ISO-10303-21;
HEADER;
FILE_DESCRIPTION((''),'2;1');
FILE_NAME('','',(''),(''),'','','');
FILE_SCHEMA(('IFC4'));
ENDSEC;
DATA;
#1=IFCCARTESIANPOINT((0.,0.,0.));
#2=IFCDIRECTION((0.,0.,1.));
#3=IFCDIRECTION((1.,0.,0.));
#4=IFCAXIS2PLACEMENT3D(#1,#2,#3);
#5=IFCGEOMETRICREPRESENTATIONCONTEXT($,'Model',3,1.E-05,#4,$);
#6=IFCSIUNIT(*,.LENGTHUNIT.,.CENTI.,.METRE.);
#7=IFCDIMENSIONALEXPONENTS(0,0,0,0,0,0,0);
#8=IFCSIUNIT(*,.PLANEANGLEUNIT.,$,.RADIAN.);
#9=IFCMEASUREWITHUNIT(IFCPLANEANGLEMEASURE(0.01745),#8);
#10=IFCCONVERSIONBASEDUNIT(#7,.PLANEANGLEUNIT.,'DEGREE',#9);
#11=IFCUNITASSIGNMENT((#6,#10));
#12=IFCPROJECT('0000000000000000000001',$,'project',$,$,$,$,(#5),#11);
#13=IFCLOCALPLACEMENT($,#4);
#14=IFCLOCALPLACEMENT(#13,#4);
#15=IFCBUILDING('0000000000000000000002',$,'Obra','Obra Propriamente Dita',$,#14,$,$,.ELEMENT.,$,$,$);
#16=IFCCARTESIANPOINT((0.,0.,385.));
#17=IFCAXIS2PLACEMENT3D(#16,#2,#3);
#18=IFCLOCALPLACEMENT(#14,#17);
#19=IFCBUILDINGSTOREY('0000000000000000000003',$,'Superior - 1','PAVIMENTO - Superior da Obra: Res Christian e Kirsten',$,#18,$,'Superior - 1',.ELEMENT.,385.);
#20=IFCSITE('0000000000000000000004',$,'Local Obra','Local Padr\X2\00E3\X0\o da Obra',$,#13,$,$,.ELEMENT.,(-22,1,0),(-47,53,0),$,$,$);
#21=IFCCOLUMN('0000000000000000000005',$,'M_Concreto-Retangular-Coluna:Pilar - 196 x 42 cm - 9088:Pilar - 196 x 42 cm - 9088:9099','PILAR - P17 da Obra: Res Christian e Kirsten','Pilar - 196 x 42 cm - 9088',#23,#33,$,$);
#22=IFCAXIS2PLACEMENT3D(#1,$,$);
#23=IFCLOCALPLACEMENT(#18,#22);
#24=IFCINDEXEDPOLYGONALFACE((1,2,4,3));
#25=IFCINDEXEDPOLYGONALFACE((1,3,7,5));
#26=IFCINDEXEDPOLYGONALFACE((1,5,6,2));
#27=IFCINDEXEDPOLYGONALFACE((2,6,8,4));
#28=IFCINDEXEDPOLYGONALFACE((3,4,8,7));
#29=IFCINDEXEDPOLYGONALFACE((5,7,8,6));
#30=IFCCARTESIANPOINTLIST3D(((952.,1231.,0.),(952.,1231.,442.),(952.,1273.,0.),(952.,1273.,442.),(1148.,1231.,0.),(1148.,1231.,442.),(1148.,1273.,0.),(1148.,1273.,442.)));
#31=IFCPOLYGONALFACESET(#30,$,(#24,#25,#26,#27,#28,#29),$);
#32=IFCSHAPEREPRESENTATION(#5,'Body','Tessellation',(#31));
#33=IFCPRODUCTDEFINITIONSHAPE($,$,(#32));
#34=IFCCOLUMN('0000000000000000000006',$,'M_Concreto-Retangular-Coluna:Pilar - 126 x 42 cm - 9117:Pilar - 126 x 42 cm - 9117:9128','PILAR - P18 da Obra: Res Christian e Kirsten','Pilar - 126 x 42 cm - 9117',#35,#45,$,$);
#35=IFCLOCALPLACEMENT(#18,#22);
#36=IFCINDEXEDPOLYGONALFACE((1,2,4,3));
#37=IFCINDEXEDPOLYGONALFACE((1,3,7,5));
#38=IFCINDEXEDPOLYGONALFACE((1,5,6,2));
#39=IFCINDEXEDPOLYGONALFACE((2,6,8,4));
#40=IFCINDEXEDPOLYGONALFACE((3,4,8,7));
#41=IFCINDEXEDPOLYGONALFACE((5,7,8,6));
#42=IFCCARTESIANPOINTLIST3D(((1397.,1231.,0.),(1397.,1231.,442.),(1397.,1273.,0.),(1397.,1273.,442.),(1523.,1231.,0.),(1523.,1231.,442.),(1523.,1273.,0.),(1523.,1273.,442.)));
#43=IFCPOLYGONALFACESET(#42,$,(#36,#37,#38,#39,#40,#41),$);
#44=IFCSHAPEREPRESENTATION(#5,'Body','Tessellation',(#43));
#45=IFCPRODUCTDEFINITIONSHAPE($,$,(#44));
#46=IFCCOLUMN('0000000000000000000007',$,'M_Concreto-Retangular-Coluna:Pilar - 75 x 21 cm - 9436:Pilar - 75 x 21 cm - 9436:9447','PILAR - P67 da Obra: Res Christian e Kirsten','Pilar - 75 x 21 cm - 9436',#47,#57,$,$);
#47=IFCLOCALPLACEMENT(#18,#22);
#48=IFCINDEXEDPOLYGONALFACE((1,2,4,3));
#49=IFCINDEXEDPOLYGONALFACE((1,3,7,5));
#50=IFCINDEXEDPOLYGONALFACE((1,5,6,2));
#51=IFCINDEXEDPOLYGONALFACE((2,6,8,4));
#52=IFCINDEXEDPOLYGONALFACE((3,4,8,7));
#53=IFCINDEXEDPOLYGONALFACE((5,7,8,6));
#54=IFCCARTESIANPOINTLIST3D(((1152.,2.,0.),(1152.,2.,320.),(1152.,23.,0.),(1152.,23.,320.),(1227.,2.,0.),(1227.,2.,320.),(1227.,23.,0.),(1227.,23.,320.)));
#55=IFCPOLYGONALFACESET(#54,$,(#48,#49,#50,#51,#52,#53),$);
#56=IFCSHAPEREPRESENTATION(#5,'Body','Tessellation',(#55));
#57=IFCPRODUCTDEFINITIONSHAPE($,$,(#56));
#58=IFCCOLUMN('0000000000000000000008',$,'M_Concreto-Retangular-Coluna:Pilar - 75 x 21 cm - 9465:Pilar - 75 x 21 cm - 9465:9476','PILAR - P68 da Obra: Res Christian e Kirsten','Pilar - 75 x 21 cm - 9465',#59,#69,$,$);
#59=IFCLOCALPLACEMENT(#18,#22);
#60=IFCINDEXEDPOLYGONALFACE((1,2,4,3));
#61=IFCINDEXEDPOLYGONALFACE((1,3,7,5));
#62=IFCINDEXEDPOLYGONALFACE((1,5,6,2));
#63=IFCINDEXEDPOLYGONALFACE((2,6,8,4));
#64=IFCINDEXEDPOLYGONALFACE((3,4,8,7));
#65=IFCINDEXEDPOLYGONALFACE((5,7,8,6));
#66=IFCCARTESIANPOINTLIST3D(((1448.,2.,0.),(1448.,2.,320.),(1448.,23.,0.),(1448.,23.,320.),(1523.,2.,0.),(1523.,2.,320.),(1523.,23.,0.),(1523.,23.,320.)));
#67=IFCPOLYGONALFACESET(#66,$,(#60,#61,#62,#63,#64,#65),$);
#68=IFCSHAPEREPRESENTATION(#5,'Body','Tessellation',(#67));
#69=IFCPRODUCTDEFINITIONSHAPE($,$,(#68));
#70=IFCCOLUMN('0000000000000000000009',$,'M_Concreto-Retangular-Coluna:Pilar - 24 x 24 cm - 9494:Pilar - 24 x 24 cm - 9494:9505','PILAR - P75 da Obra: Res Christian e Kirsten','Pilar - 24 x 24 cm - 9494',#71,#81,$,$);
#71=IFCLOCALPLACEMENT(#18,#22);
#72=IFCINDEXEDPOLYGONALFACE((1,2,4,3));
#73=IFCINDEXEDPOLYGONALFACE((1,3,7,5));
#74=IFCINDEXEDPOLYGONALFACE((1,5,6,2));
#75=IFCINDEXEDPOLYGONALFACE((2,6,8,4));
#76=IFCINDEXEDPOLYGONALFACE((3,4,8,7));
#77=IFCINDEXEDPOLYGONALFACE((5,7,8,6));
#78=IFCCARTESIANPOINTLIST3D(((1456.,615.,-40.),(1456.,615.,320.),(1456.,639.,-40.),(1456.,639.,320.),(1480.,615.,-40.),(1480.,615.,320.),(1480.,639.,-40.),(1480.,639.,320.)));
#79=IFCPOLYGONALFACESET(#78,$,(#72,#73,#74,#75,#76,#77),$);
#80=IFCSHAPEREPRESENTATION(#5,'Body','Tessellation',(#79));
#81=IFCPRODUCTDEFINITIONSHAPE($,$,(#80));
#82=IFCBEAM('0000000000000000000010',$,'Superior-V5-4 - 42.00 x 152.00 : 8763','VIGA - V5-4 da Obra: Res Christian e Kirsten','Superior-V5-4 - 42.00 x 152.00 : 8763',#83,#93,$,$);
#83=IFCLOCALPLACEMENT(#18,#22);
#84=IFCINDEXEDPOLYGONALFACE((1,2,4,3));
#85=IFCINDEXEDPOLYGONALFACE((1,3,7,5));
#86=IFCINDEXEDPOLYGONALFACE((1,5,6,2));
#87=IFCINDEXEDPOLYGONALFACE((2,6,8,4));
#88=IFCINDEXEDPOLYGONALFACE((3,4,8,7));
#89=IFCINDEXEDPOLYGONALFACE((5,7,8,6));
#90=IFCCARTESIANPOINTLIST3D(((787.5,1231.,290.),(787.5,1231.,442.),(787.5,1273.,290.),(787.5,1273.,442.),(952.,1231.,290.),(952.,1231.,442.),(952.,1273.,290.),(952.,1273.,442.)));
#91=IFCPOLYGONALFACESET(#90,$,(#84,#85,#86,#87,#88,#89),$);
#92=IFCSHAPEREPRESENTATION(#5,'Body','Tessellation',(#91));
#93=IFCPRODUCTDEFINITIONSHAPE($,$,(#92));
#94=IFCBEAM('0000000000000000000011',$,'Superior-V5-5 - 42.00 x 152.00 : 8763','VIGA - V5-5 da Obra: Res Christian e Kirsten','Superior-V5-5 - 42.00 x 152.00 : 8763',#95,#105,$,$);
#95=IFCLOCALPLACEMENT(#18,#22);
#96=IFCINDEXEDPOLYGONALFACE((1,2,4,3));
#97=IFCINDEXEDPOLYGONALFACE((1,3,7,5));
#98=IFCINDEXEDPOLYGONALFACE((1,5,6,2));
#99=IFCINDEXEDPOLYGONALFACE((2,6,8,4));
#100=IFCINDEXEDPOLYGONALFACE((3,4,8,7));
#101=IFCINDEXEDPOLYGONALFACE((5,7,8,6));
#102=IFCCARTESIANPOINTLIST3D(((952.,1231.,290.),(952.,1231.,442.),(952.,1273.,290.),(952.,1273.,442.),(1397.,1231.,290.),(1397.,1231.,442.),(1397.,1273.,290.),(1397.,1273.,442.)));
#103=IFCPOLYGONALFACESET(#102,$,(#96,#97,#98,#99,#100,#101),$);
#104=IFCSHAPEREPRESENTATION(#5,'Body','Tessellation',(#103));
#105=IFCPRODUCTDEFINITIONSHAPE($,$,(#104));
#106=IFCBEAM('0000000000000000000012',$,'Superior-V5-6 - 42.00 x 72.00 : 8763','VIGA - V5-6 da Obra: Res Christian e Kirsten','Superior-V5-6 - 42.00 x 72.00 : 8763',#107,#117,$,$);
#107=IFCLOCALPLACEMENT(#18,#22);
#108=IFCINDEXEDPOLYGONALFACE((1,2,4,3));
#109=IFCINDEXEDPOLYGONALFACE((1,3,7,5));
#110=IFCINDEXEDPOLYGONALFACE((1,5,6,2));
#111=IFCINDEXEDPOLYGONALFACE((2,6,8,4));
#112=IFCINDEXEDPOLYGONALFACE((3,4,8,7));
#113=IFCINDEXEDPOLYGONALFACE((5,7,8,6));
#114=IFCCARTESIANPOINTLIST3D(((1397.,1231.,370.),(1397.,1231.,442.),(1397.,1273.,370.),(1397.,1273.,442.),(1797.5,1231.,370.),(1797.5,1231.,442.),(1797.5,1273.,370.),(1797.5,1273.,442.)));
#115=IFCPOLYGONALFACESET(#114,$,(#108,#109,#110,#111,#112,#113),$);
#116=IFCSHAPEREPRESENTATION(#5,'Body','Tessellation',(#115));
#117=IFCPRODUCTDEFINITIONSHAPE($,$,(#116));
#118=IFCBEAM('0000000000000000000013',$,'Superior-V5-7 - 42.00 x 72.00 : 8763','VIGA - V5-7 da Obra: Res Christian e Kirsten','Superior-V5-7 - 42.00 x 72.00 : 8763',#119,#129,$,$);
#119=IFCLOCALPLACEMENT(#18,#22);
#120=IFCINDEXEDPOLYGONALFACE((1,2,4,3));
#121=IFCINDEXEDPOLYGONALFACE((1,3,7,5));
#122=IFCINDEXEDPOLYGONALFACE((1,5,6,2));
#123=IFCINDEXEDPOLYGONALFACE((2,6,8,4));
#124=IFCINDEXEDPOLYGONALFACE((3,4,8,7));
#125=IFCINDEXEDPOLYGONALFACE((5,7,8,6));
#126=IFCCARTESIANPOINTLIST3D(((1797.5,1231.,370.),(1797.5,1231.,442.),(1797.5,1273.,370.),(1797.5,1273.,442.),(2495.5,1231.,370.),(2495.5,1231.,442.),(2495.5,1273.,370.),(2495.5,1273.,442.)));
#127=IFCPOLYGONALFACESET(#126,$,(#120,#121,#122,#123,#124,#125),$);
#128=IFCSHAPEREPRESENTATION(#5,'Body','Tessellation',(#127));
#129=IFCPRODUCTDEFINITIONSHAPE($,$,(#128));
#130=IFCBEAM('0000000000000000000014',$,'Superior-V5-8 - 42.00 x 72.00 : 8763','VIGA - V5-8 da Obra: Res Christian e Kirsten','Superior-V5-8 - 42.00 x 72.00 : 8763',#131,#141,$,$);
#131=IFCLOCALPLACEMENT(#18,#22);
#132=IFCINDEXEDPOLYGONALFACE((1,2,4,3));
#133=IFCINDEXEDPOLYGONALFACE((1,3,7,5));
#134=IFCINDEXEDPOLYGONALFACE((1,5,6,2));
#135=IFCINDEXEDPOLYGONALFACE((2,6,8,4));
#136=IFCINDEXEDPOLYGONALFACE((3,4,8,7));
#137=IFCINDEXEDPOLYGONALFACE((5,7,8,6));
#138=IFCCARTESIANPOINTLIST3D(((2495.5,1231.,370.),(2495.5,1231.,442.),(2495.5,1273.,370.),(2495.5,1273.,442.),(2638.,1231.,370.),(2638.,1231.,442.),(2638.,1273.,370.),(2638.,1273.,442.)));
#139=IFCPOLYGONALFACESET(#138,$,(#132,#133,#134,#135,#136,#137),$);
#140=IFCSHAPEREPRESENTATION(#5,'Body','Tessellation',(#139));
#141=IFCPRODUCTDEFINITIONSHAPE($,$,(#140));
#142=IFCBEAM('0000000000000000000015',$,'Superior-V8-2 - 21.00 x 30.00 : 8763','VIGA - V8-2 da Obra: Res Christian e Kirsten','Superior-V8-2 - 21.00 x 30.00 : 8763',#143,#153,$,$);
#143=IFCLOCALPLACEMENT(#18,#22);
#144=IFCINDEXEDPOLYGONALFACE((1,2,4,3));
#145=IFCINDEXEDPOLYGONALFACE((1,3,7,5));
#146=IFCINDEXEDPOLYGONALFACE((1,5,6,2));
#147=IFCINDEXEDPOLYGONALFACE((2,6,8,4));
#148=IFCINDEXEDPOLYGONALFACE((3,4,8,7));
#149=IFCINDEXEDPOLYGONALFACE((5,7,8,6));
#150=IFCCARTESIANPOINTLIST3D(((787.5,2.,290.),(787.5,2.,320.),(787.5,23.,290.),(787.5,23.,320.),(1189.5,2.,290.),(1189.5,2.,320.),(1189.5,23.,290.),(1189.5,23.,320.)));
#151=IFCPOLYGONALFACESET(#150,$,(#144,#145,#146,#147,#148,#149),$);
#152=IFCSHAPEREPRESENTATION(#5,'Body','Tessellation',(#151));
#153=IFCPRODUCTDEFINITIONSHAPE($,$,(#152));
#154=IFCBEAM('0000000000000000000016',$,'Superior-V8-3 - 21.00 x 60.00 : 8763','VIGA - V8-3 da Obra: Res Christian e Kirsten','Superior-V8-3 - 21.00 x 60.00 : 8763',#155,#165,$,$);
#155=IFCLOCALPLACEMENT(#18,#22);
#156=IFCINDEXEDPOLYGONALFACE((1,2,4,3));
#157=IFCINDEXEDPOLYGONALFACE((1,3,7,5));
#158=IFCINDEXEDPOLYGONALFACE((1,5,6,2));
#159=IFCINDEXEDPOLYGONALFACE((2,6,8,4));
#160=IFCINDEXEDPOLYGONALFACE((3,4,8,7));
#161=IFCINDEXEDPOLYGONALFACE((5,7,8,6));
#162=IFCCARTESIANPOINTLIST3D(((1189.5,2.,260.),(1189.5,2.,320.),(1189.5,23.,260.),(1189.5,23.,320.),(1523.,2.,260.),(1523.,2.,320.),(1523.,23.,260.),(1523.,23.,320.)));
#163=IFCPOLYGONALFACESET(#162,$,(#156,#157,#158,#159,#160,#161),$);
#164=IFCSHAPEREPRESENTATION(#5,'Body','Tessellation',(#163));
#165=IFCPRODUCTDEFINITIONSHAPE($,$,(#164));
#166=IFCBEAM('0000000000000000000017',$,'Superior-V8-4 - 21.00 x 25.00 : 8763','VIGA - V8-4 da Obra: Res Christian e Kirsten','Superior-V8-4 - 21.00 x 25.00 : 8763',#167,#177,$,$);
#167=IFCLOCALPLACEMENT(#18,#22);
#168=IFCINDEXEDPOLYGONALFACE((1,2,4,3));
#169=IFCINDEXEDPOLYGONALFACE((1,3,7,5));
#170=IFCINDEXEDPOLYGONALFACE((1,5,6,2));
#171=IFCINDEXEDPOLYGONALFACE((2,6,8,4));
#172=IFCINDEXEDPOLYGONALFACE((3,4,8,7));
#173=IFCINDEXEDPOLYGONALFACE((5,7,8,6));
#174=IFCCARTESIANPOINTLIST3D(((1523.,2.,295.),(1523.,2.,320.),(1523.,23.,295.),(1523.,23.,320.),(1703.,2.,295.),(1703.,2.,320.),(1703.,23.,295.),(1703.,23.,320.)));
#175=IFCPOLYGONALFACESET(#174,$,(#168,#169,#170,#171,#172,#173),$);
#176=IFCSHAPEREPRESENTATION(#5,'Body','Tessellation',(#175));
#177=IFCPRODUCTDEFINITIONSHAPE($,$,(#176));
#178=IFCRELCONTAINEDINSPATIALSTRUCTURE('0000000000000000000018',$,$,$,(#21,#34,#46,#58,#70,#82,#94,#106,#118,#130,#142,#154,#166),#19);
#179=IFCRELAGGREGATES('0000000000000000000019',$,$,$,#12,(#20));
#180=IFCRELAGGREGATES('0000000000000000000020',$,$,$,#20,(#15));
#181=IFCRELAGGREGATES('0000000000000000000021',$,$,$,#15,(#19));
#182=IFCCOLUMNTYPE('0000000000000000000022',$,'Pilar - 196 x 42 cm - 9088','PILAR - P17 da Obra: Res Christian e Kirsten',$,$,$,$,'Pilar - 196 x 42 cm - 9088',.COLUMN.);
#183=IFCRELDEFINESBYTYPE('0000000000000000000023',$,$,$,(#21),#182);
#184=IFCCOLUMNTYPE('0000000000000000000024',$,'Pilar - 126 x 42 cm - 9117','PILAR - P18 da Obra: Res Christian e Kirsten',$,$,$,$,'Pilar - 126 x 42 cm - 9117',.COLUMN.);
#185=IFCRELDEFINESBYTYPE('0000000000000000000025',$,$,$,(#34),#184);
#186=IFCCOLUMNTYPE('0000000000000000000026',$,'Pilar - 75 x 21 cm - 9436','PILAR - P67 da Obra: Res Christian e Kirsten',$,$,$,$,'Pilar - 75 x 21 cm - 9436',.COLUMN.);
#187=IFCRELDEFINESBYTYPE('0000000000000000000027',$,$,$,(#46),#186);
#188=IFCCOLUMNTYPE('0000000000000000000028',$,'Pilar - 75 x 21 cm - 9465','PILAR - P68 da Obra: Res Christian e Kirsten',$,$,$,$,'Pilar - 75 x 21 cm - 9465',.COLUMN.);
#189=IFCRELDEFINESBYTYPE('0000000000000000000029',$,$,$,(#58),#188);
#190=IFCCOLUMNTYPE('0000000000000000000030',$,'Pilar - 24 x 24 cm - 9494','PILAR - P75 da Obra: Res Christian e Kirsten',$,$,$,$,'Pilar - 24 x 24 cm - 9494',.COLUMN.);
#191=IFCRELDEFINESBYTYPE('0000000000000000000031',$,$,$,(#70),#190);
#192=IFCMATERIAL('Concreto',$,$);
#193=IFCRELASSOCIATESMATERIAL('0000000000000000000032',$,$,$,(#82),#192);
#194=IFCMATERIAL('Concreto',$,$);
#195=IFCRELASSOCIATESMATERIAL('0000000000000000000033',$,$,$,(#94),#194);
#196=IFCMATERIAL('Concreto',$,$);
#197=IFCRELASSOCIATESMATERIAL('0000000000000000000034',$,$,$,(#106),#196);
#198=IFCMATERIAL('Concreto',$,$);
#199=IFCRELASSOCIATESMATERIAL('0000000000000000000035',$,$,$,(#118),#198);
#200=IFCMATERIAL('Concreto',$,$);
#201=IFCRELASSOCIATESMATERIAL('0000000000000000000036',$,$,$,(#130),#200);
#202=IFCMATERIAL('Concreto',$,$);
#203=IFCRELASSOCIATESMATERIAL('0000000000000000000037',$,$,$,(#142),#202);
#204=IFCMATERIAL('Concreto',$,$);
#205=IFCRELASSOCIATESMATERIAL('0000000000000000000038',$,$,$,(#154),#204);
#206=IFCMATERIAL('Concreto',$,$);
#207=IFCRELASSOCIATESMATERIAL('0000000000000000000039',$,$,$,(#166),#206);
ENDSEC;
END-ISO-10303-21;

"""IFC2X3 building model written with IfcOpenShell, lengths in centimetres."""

from ifc_helpers import new_model, entity, si_unit, converted_unit, frame, origin, origin_with_axes, origin_2d_with_axis, place, context, project, spatial, polyline, rectangle, outline, extrude, source, transform, mapped, material, type_object, type_shapes, element, save


model = new_model("IFC2X3")

# Units and contexts
model_context = context("Model", 3, precision=1e-05, world=origin_with_axes())
ifc_project = project(units=[si_unit("LENGTHUNIT", "METRE", prefix="CENTI"), converted_unit("PLANEANGLEUNIT", "DEGREE", entity("IfcPlaneAngleMeasure", 0.01745), si_unit("PLANEANGLEUNIT", "RADIAN"), dimensions=[0, 0, 0, 0, 0, 0, 0])], contexts=[model_context])

# Site, building, storey
site_placement = place(None, origin_with_axes())
site = spatial("IfcSite", under=ifc_project, at=site_placement, Name="Local Obra", Description="Local Padrão da Obra", CompositionType="ELEMENT", RefLatitude=(-22, 1, 0), RefLongitude=(-47, 53, 0))
building_placement = place(site_placement, origin_with_axes())
building = spatial("IfcBuilding", under=site, at=building_placement, Name="Obra", Description="Obra Propriamente Dita", CompositionType="ELEMENT")
storey_placement = place(building_placement, frame((0.0, 0.0, 385.0), z_axis=(0.0, 0.0, 1.0), x_axis=(1.0, 0.0, 0.0)))
storey = spatial("IfcBuildingStorey", under=building, at=storey_placement, Name="Superior - 1", Description="PAVIMENTO - Superior da Obra: Res Christian e Kirsten", LongName="Superior - 1", CompositionType="ELEMENT", Elevation=385.0)

# Columns
column_type_1 = type_object("IfcColumnType", Name="Pilar - 196 x 42 cm - 9088", Description="PILAR - P17 da Obra: Res Christian e Kirsten", ElementType="Pilar - 196 x 42 cm - 9088", PredefinedType="COLUMN")
shared_shape_1 = source(origin(), model_context, "Body", "SweptSolid", [
    extrude(rectangle(XDim=196.0, YDim=42.0, at=origin_2d_with_axis()), origin(), (0.0, 0.0, 1.0), 442.0),
])
type_shapes(column_type_1, [shared_shape_1])
column_1_placement = place(storey_placement, frame((1050.0, 1252.0, 0.0), z_axis=(0.0, 0.0, 1.0), x_axis=(1.0, 0.0, 0.0)))
element("IfcColumn", 1, at=column_1_placement, inside=storey, type_object=column_type_1, Name="M_Concreto-Retangular-Coluna:Pilar - 196 x 42 cm - 9088:Pilar - 196 x 42 cm - 9088:9099", Description="PILAR - P17 da Obra: Res Christian e Kirsten", ObjectType="Pilar - 196 x 42 cm - 9088", context=model_context, shape_type="MappedRepresentation", body=[
    mapped(shared_shape_1, transform((0.0, 0.0, 0.0), scale=1.0)),
])
column_type_2 = type_object("IfcColumnType", Name="Pilar - 126 x 42 cm - 9117", Description="PILAR - P18 da Obra: Res Christian e Kirsten", ElementType="Pilar - 126 x 42 cm - 9117", PredefinedType="COLUMN")
shared_shape_2 = source(origin(), model_context, "Body", "SweptSolid", [
    extrude(rectangle(XDim=126.0, YDim=42.0, at=origin_2d_with_axis()), origin(), (0.0, 0.0, 1.0), 442.0),
])
type_shapes(column_type_2, [shared_shape_2])
column_2_placement = place(storey_placement, frame((1460.0, 1252.0, 0.0), z_axis=(0.0, 0.0, 1.0), x_axis=(1.0, 0.0, 0.0)))
element("IfcColumn", 2, at=column_2_placement, inside=storey, type_object=column_type_2, Name="M_Concreto-Retangular-Coluna:Pilar - 126 x 42 cm - 9117:Pilar - 126 x 42 cm - 9117:9128", Description="PILAR - P18 da Obra: Res Christian e Kirsten", ObjectType="Pilar - 126 x 42 cm - 9117", context=model_context, shape_type="MappedRepresentation", body=[
    mapped(shared_shape_2, transform((0.0, 0.0, 0.0), scale=1.0)),
])
column_type_3 = type_object("IfcColumnType", Name="Pilar - 75 x 21 cm - 9436", Description="PILAR - P67 da Obra: Res Christian e Kirsten", ElementType="Pilar - 75 x 21 cm - 9436", PredefinedType="COLUMN")
shared_shape_3 = source(origin(), model_context, "Body", "SweptSolid", [
    extrude(rectangle(XDim=75.0, YDim=21.0, at=origin_2d_with_axis()), origin(), (0.0, 0.0, 1.0), 320.0),
])
type_shapes(column_type_3, [shared_shape_3])
column_3_placement = place(storey_placement, frame((1189.5, 12.5, 0.0), z_axis=(0.0, 0.0, 1.0), x_axis=(1.0, 0.0, 0.0)))
element("IfcColumn", 3, at=column_3_placement, inside=storey, type_object=column_type_3, Name="M_Concreto-Retangular-Coluna:Pilar - 75 x 21 cm - 9436:Pilar - 75 x 21 cm - 9436:9447", Description="PILAR - P67 da Obra: Res Christian e Kirsten", ObjectType="Pilar - 75 x 21 cm - 9436", context=model_context, shape_type="MappedRepresentation", body=[
    mapped(shared_shape_3, transform((0.0, 0.0, 0.0), scale=1.0)),
])
column_type_4 = type_object("IfcColumnType", Name="Pilar - 75 x 21 cm - 9465", Description="PILAR - P68 da Obra: Res Christian e Kirsten", ElementType="Pilar - 75 x 21 cm - 9465", PredefinedType="COLUMN")
shared_shape_4 = source(origin(), model_context, "Body", "SweptSolid", [
    extrude(rectangle(XDim=75.0, YDim=21.0, at=origin_2d_with_axis()), origin(), (0.0, 0.0, 1.0), 320.0),
])
type_shapes(column_type_4, [shared_shape_4])
column_4_placement = place(storey_placement, frame((1485.5, 12.5, 0.0), z_axis=(0.0, 0.0, 1.0), x_axis=(1.0, 0.0, 0.0)))
element("IfcColumn", 4, at=column_4_placement, inside=storey, type_object=column_type_4, Name="M_Concreto-Retangular-Coluna:Pilar - 75 x 21 cm - 9465:Pilar - 75 x 21 cm - 9465:9476", Description="PILAR - P68 da Obra: Res Christian e Kirsten", ObjectType="Pilar - 75 x 21 cm - 9465", context=model_context, shape_type="MappedRepresentation", body=[
    mapped(shared_shape_4, transform((0.0, 0.0, 0.0), scale=1.0)),
])
column_type_5 = type_object("IfcColumnType", Name="Pilar - 24 x 24 cm - 9494", Description="PILAR - P75 da Obra: Res Christian e Kirsten", ElementType="Pilar - 24 x 24 cm - 9494", PredefinedType="COLUMN")
shared_shape_5 = source(origin(), model_context, "Body", "SweptSolid", [
    extrude(rectangle(XDim=24.0, YDim=24.0, at=origin_2d_with_axis()), origin(), (0.0, 0.0, 1.0), 360.0),
])
type_shapes(column_type_5, [shared_shape_5])
column_5_placement = place(storey_placement, frame((1468.0, 627.0, -40.0), z_axis=(0.0, 0.0, 1.0), x_axis=(1.0, 0.0, 0.0)))
element("IfcColumn", 5, at=column_5_placement, inside=storey, type_object=column_type_5, Name="M_Concreto-Retangular-Coluna:Pilar - 24 x 24 cm - 9494:Pilar - 24 x 24 cm - 9494:9505", Description="PILAR - P75 da Obra: Res Christian e Kirsten", ObjectType="Pilar - 24 x 24 cm - 9494", context=model_context, shape_type="MappedRepresentation", body=[
    mapped(shared_shape_5, transform((0.0, 0.0, 0.0), scale=1.0)),
])

# Beams
ifc_material_1 = material(Name="Concreto")
beam_1_placement = place(storey_placement, frame((787.5, 1252.0, 442.0), z_axis=(1.0, 0.0, 0.0), x_axis=(0.0, -1.0, 0.0)))
element("IfcBeam", 6, at=beam_1_placement, inside=storey, material=ifc_material_1, Name="Superior-V5-4 - 42.00 x 152.00 : 8763", Description="VIGA - V5-4 da Obra: Res Christian e Kirsten", ObjectType="Superior-V5-4 - 42.00 x 152.00 : 8763", context=model_context, shape_type="SweptSolid", body=[
    extrude(outline(polyline([(-21.0, 0.0), (21.0, 0.0), (21.0, 152.0), (-21.0, 152.0), (-21.0, 0.0)])), origin_with_axes(), (0.0, 0.0, 1.0), 164.5),
])
ifc_material_2 = material(Name="Concreto")
beam_2_placement = place(storey_placement, frame((952.0, 1252.0, 442.0), z_axis=(1.0, 0.0, 0.0), x_axis=(0.0, -1.0, 0.0)))
element("IfcBeam", 7, at=beam_2_placement, inside=storey, material=ifc_material_2, Name="Superior-V5-5 - 42.00 x 152.00 : 8763", Description="VIGA - V5-5 da Obra: Res Christian e Kirsten", ObjectType="Superior-V5-5 - 42.00 x 152.00 : 8763", context=model_context, shape_type="SweptSolid", body=[
    extrude(outline(polyline([(-21.0, 0.0), (21.0, 0.0), (21.0, 152.0), (-21.0, 152.0), (-21.0, 0.0)])), origin_with_axes(), (0.0, 0.0, 1.0), 445.0),
])
ifc_material_3 = material(Name="Concreto")
beam_3_placement = place(storey_placement, frame((1397.0, 1252.0, 442.0), z_axis=(1.0, 0.0, 0.0), x_axis=(0.0, -1.0, 0.0)))
element("IfcBeam", 8, at=beam_3_placement, inside=storey, material=ifc_material_3, Name="Superior-V5-6 - 42.00 x 72.00 : 8763", Description="VIGA - V5-6 da Obra: Res Christian e Kirsten", ObjectType="Superior-V5-6 - 42.00 x 72.00 : 8763", context=model_context, shape_type="SweptSolid", body=[
    extrude(outline(polyline([(-21.0, 0.0), (21.0, 0.0), (21.0, 72.0), (-21.0, 72.0), (-21.0, 0.0)])), origin_with_axes(), (0.0, 0.0, 1.0), 400.5),
])
ifc_material_4 = material(Name="Concreto")
beam_4_placement = place(storey_placement, frame((1797.5, 1252.0, 442.0), z_axis=(1.0, 0.0, 0.0), x_axis=(0.0, -1.0, 0.0)))
element("IfcBeam", 9, at=beam_4_placement, inside=storey, material=ifc_material_4, Name="Superior-V5-7 - 42.00 x 72.00 : 8763", Description="VIGA - V5-7 da Obra: Res Christian e Kirsten", ObjectType="Superior-V5-7 - 42.00 x 72.00 : 8763", context=model_context, shape_type="SweptSolid", body=[
    extrude(outline(polyline([(-21.0, 0.0), (21.0, 0.0), (21.0, 72.0), (-21.0, 72.0), (-21.0, 0.0)])), origin_with_axes(), (0.0, 0.0, 1.0), 698.0),
])
ifc_material_5 = material(Name="Concreto")
beam_5_placement = place(storey_placement, frame((2495.5, 1252.0, 442.0), z_axis=(1.0, 0.0, 0.0), x_axis=(0.0, -1.0, 0.0)))
element("IfcBeam", 10, at=beam_5_placement, inside=storey, material=ifc_material_5, Name="Superior-V5-8 - 42.00 x 72.00 : 8763", Description="VIGA - V5-8 da Obra: Res Christian e Kirsten", ObjectType="Superior-V5-8 - 42.00 x 72.00 : 8763", context=model_context, shape_type="SweptSolid", body=[
    extrude(outline(polyline([(-21.0, 0.0), (21.0, 0.0), (21.0, 72.0), (-21.0, 72.0), (-21.0, 0.0)])), origin_with_axes(), (0.0, 0.0, 1.0), 142.5),
])
ifc_material_6 = material(Name="Concreto")
beam_6_placement = place(storey_placement, frame((787.5, 2.0, 320.0), z_axis=(1.0, 0.0, 0.0), x_axis=(0.0, -1.0, 0.0)))
element("IfcBeam", 11, at=beam_6_placement, inside=storey, material=ifc_material_6, Name="Superior-V8-2 - 21.00 x 30.00 : 8763", Description="VIGA - V8-2 da Obra: Res Christian e Kirsten", ObjectType="Superior-V8-2 - 21.00 x 30.00 : 8763", context=model_context, shape_type="SweptSolid", body=[
    extrude(outline(polyline([(-21.0, 0.0), (0.0, 0.0), (0.0, 30.0), (-21.0, 30.0), (-21.0, 0.0)])), origin_with_axes(), (0.0, 0.0, 1.0), 402.0),
])
ifc_material_7 = material(Name="Concreto")
beam_7_placement = place(storey_placement, frame((1189.5, 2.0, 320.0), z_axis=(1.0, 0.0, 0.0), x_axis=(0.0, -1.0, 0.0)))
element("IfcBeam", 12, at=beam_7_placement, inside=storey, material=ifc_material_7, Name="Superior-V8-3 - 21.00 x 60.00 : 8763", Description="VIGA - V8-3 da Obra: Res Christian e Kirsten", ObjectType="Superior-V8-3 - 21.00 x 60.00 : 8763", context=model_context, shape_type="SweptSolid", body=[
    extrude(outline(polyline([(-21.0, 0.0), (0.0, 0.0), (0.0, 60.0), (-21.0, 60.0), (-21.0, 0.0)])), origin_with_axes(), (0.0, 0.0, 1.0), 333.5),
])
ifc_material_8 = material(Name="Concreto")
beam_8_placement = place(storey_placement, frame((1523.0, 2.0, 320.0), z_axis=(1.0, 0.0, 0.0), x_axis=(0.0, -1.0, 0.0)))
element("IfcBeam", 13, at=beam_8_placement, inside=storey, material=ifc_material_8, Name="Superior-V8-4 - 21.00 x 25.00 : 8763", Description="VIGA - V8-4 da Obra: Res Christian e Kirsten", ObjectType="Superior-V8-4 - 21.00 x 25.00 : 8763", context=model_context, shape_type="SweptSolid", body=[
    extrude(outline(polyline([(-21.0, 0.0), (0.0, 0.0), (0.0, 25.0), (-21.0, 25.0), (-21.0, 0.0)])), origin_with_axes(), (0.0, 0.0, 1.0), 180.0),
])

save(model, "model.ifc")
